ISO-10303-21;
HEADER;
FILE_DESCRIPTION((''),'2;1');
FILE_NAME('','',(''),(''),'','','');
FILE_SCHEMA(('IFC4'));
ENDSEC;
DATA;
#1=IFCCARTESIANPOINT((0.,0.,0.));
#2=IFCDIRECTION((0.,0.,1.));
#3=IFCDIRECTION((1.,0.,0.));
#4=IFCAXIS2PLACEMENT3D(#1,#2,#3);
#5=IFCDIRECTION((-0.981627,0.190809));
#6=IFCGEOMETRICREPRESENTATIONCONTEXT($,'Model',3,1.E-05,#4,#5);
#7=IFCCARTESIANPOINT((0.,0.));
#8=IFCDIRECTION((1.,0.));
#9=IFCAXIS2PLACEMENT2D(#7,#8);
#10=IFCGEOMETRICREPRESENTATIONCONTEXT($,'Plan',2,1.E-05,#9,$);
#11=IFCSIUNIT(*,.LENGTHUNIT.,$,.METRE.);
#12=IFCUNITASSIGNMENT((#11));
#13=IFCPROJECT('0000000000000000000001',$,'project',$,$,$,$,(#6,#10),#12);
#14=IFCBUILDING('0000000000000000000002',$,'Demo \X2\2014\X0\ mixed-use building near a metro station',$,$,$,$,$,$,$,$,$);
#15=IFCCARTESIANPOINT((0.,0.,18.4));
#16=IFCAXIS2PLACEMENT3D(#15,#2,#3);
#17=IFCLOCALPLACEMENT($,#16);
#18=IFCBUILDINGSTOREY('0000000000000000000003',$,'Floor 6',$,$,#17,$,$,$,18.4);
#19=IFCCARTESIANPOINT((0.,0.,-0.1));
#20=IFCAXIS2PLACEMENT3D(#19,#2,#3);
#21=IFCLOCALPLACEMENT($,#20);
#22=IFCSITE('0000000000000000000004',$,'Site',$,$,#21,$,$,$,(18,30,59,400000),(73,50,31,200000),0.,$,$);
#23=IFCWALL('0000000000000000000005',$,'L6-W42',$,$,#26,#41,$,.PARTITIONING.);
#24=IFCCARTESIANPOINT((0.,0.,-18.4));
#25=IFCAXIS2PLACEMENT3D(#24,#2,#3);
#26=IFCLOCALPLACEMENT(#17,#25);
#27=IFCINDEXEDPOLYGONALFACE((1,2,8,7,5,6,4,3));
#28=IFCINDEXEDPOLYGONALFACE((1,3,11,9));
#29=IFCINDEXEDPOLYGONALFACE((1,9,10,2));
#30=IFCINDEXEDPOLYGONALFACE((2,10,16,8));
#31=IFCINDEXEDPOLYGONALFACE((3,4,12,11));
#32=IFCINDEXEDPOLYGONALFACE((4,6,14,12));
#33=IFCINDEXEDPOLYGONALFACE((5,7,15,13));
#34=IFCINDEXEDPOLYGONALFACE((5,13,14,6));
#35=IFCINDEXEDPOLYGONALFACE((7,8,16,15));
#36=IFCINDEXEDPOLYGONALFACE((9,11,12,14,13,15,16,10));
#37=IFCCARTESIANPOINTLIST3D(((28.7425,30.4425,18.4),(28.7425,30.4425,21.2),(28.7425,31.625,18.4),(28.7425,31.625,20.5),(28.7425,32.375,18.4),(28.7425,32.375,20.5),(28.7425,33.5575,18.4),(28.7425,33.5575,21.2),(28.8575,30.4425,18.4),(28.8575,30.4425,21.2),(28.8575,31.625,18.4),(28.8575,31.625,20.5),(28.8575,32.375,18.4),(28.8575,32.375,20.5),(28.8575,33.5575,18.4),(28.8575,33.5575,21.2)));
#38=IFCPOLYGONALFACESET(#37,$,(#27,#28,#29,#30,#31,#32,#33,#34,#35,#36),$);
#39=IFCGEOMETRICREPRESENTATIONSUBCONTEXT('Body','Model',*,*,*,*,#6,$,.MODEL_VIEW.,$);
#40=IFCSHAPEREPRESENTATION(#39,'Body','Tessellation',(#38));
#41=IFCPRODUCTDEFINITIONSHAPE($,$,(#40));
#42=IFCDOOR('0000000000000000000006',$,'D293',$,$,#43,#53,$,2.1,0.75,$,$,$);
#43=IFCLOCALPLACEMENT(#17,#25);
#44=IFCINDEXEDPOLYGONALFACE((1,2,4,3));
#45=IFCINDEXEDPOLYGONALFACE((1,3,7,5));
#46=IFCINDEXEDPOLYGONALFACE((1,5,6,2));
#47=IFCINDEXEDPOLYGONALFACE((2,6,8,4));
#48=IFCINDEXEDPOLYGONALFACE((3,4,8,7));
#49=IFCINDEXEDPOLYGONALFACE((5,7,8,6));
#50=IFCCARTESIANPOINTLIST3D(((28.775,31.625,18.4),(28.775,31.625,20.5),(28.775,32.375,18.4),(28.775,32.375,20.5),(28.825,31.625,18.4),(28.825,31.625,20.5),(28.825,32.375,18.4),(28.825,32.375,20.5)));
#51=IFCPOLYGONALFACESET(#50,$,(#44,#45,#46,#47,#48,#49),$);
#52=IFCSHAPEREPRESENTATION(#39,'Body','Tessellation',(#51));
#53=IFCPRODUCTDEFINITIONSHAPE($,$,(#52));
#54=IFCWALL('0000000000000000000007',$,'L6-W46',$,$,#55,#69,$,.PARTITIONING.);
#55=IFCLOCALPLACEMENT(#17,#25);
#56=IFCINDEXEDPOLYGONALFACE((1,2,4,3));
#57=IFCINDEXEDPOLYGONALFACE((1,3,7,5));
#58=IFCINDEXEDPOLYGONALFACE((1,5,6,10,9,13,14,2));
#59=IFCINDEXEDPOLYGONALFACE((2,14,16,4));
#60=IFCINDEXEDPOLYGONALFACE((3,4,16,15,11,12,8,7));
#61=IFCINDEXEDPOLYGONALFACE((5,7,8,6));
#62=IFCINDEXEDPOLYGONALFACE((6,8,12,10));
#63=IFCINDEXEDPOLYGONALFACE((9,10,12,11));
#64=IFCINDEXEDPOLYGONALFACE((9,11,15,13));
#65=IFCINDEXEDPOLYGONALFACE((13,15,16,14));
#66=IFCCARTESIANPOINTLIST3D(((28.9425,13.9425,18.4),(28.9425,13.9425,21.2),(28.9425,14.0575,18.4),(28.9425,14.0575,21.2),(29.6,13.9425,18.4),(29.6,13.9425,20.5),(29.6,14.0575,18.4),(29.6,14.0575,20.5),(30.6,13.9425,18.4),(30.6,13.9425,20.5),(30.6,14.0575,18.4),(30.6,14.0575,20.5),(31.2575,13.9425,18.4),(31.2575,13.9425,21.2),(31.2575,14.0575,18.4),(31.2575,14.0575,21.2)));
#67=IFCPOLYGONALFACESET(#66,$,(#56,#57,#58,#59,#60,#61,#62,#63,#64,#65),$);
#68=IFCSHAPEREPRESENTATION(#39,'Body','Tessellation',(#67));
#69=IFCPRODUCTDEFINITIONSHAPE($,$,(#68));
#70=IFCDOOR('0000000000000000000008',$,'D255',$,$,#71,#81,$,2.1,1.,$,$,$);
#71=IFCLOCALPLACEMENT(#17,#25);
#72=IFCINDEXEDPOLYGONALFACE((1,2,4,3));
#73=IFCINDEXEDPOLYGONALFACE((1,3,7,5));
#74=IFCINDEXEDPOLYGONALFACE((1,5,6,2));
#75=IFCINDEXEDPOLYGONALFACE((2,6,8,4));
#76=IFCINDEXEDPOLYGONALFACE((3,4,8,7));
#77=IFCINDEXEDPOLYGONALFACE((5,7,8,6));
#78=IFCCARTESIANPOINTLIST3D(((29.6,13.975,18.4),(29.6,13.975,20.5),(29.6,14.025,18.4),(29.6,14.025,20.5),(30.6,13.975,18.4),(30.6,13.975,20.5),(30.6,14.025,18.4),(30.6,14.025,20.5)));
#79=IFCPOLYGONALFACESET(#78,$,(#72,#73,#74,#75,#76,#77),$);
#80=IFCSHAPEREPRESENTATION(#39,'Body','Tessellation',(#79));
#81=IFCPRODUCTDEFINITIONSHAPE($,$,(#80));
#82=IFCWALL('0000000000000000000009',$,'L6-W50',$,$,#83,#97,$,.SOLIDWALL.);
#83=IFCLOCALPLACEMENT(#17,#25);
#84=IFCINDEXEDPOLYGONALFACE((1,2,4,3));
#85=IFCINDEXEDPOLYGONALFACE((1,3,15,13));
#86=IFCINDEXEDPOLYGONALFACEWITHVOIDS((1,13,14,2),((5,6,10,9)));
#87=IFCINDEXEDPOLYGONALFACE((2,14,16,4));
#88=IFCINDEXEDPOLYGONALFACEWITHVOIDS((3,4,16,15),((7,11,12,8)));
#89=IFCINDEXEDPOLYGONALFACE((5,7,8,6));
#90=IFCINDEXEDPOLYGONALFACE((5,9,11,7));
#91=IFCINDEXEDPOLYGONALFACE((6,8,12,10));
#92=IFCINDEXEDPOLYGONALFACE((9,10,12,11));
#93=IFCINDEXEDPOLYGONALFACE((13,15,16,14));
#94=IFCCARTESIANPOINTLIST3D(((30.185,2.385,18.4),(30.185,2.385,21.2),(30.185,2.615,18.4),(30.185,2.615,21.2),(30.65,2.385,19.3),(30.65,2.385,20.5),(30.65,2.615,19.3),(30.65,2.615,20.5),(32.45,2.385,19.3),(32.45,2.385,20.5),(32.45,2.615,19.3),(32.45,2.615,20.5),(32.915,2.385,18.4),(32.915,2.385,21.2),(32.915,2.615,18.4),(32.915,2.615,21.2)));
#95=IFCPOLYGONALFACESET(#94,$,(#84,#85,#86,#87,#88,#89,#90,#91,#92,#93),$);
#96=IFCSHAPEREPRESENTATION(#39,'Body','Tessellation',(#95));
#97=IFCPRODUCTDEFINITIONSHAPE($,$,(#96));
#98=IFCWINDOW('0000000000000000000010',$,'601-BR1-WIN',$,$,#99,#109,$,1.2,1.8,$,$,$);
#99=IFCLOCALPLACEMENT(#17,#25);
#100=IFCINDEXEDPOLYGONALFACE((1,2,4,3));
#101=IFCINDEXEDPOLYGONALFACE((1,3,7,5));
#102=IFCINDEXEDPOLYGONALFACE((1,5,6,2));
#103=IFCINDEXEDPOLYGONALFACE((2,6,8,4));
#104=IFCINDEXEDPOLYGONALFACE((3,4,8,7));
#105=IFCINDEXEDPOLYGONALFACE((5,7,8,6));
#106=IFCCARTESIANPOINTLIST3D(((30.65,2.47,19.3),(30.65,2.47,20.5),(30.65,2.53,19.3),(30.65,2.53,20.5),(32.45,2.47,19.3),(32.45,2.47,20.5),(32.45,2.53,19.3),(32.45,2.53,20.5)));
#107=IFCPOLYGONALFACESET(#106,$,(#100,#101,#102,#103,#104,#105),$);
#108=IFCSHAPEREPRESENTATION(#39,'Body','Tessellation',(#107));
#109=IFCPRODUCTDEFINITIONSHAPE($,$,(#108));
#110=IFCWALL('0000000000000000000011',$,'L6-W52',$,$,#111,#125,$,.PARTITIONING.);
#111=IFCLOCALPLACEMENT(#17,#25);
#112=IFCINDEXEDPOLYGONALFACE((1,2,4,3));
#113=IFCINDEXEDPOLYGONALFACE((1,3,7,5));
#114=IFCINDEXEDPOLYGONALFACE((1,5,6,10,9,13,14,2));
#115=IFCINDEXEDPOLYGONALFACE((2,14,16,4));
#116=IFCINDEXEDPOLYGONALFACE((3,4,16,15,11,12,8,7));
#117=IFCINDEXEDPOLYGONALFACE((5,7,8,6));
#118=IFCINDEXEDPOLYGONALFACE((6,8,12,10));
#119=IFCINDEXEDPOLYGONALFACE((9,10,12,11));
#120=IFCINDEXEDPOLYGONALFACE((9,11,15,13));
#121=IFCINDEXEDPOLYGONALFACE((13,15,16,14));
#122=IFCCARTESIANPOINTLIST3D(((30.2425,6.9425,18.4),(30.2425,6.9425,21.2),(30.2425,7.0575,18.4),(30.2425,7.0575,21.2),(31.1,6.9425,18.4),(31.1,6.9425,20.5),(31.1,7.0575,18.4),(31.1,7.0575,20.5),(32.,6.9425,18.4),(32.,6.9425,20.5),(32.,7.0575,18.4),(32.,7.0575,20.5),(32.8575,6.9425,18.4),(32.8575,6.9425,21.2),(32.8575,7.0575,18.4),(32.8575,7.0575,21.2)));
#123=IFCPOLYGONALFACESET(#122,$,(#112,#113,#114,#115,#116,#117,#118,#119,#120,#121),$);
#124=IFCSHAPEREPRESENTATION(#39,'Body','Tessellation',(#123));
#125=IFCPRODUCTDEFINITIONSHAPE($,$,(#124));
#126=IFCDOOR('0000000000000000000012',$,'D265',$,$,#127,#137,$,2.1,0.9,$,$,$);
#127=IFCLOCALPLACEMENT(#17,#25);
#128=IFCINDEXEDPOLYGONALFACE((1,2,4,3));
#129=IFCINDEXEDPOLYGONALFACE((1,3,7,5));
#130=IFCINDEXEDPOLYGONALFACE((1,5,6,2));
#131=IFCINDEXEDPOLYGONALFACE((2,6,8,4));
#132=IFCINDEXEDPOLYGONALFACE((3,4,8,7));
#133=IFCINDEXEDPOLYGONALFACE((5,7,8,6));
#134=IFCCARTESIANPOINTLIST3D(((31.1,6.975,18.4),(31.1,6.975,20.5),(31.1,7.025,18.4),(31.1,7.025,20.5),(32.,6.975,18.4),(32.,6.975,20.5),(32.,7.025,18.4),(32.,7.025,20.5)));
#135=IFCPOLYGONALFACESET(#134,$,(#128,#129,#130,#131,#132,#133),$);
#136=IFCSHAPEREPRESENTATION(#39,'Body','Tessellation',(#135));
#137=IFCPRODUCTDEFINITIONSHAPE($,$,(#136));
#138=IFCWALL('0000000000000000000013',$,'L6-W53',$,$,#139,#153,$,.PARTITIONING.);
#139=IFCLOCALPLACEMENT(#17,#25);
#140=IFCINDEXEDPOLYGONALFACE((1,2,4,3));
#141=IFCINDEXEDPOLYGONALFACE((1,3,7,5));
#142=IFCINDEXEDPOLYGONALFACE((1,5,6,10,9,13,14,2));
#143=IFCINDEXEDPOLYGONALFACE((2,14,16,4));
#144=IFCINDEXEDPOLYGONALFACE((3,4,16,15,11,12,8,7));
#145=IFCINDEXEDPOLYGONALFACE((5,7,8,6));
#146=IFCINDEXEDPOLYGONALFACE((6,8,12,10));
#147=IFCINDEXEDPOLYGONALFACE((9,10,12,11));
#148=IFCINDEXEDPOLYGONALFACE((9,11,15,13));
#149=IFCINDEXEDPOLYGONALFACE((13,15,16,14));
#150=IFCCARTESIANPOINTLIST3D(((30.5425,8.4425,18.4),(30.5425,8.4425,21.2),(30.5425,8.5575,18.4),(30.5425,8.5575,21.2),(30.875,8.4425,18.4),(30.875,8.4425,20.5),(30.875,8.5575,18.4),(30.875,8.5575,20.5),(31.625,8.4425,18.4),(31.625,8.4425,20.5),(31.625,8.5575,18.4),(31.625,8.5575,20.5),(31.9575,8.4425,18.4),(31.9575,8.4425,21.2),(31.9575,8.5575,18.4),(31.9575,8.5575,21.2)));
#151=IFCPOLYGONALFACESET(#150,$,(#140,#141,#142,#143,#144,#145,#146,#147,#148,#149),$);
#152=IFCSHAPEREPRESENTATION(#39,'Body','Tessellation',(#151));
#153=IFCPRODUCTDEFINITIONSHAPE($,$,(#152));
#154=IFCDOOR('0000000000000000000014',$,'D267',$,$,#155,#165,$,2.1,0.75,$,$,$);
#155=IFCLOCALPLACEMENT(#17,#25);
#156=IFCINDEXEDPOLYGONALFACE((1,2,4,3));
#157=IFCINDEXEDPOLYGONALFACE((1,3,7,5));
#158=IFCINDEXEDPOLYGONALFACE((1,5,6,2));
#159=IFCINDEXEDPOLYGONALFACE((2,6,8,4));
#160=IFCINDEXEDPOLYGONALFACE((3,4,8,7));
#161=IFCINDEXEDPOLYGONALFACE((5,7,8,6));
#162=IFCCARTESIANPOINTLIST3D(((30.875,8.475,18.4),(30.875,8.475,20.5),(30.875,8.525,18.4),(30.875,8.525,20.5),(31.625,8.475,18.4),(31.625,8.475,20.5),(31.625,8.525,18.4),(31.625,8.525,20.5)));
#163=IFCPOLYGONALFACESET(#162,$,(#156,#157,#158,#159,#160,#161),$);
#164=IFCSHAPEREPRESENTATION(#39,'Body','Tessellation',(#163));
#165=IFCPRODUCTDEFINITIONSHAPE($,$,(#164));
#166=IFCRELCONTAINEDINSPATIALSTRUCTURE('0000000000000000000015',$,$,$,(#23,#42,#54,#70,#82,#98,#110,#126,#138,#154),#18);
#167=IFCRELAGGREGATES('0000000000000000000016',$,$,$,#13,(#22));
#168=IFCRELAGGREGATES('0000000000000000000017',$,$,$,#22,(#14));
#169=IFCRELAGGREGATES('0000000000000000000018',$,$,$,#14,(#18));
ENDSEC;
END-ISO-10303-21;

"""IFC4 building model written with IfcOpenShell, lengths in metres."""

from ifc_helpers import new_model, si_unit, direction, frame, origin_with_axes, origin_2d_with_axis, place, context, subcontext, project, spatial, line, indexed_curve, outline, extrude, element, fill, save


model = new_model("IFC4")

# Units and contexts
model_context = context("Model", 3, precision=1e-05, world=origin_with_axes(), true_north=direction((-0.981627, 0.190809)))
plan_context = context("Plan", 2, precision=1e-05, world=origin_2d_with_axis())
body_context = subcontext(model_context, "Body", "Model", "MODEL_VIEW")
ifc_project = project(units=[si_unit("LENGTHUNIT", "METRE")], contexts=[model_context, plan_context])

# Site, building, storey
site_placement = place(None, frame((0.0, 0.0, -0.1), z_axis=(0.0, 0.0, 1.0), x_axis=(1.0, 0.0, 0.0)))
site = spatial("IfcSite", under=ifc_project, at=site_placement, Name="Site", RefLatitude=(18, 30, 59, 400000), RefLongitude=(73, 50, 31, 200000), RefElevation=0.0)
building = spatial("IfcBuilding", under=site, Name="Demo — mixed-use building near a metro station")
storey_placement = place(None, frame((0.0, 0.0, 18.4), z_axis=(0.0, 0.0, 1.0), x_axis=(1.0, 0.0, 0.0)))
storey = spatial("IfcBuildingStorey", under=building, at=storey_placement, Name="Floor 6", Elevation=18.4)

# Wall, opening, door
wall_1_placement = place(storey_placement, frame((0.0, 0.0, -18.4), z_axis=(0.0, 0.0, 1.0), x_axis=(1.0, 0.0, 0.0)))
wall_1 = element("IfcWall", 1, at=wall_1_placement, inside=storey, Name="L6-W42", PredefinedType="PARTITIONING", context=body_context, shape_type="SweptSolid", body=[
    extrude(outline(indexed_curve([(28.7425, 30.4425), (28.7425, 33.5575), (28.8575, 33.5575), (28.8575, 30.4425)], segments=[line(1, 2, 3, 4, 1)])), frame((0.0, 0.0, 18.4), z_axis=(0.0, 0.0, 1.0), x_axis=(1.0, 0.0, 0.0)), (0.0, 0.0, 1.0), 2.8),
])
opening_1_placement = place(wall_1_placement, origin_with_axes())
opening_1 = element("IfcOpeningElement", 2, at=opening_1_placement, cuts=wall_1, context=body_context, shape_type="SweptSolid", body=[
    extrude(outline(indexed_curve([(28.6925, 31.625), (28.6925, 32.375), (28.9075, 32.375), (28.9075, 31.625)], segments=[line(1, 2, 3, 4, 1)])), frame((0.0, 0.0, 18.4), z_axis=(0.0, 0.0, 1.0), x_axis=(1.0, 0.0, 0.0)), (0.0, 0.0, 1.0), 2.1),
])
door_1_placement = place(storey_placement, frame((0.0, 0.0, -18.4), z_axis=(0.0, 0.0, 1.0), x_axis=(1.0, 0.0, 0.0)))
door_1 = element("IfcDoor", 3, at=door_1_placement, inside=storey, Name="D293", OverallHeight=2.1, OverallWidth=0.75, context=body_context, shape_type="SweptSolid", body=[
    extrude(outline(indexed_curve([(28.775, 31.625), (28.775, 32.375), (28.825, 32.375), (28.825, 31.625)], segments=[line(1, 2, 3, 4, 1)])), frame((0.0, 0.0, 18.4), z_axis=(0.0, 0.0, 1.0), x_axis=(1.0, 0.0, 0.0)), (0.0, 0.0, 1.0), 2.1),
])
fill(opening_1, door_1)

# Wall, opening, door
wall_2_placement = place(storey_placement, frame((0.0, 0.0, -18.4), z_axis=(0.0, 0.0, 1.0), x_axis=(1.0, 0.0, 0.0)))
wall_2 = element("IfcWall", 4, at=wall_2_placement, inside=storey, Name="L6-W46", PredefinedType="PARTITIONING", context=body_context, shape_type="SweptSolid", body=[
    extrude(outline(indexed_curve([(31.2575, 13.9425), (28.9425, 13.9425), (28.9425, 14.0575), (31.2575, 14.0575)], segments=[line(1, 2, 3, 4, 1)])), frame((0.0, 0.0, 18.4), z_axis=(0.0, 0.0, 1.0), x_axis=(1.0, 0.0, 0.0)), (0.0, 0.0, 1.0), 2.8),
])
opening_2_placement = place(wall_2_placement, origin_with_axes())
opening_2 = element("IfcOpeningElement", 5, at=opening_2_placement, cuts=wall_2, context=body_context, shape_type="SweptSolid", body=[
    extrude(outline(indexed_curve([(30.6, 13.8925), (29.6, 13.8925), (29.6, 14.1075), (30.6, 14.1075)], segments=[line(1, 2, 3, 4, 1)])), frame((0.0, 0.0, 18.4), z_axis=(0.0, 0.0, 1.0), x_axis=(1.0, 0.0, 0.0)), (0.0, 0.0, 1.0), 2.1),
])
door_2_placement = place(storey_placement, frame((0.0, 0.0, -18.4), z_axis=(0.0, 0.0, 1.0), x_axis=(1.0, 0.0, 0.0)))
door_2 = element("IfcDoor", 6, at=door_2_placement, inside=storey, Name="D255", OverallHeight=2.1, OverallWidth=1.0, context=body_context, shape_type="SweptSolid", body=[
    extrude(outline(indexed_curve([(30.6, 13.975), (29.6, 13.975), (29.6, 14.025), (30.6, 14.025)], segments=[line(1, 2, 3, 4, 1)])), frame((0.0, 0.0, 18.4), z_axis=(0.0, 0.0, 1.0), x_axis=(1.0, 0.0, 0.0)), (0.0, 0.0, 1.0), 2.1),
])
fill(opening_2, door_2)

# Wall, opening, window
wall_3_placement = place(storey_placement, frame((0.0, 0.0, -18.4), z_axis=(0.0, 0.0, 1.0), x_axis=(1.0, 0.0, 0.0)))
wall_3 = element("IfcWall", 7, at=wall_3_placement, inside=storey, Name="L6-W50", PredefinedType="SOLIDWALL", context=body_context, shape_type="SweptSolid", body=[
    extrude(outline(indexed_curve([(30.185, 2.615), (32.915, 2.615), (32.915, 2.385), (30.185, 2.385)], segments=[line(1, 2, 3, 4, 1)])), frame((0.0, 0.0, 18.4), z_axis=(0.0, 0.0, 1.0), x_axis=(1.0, 0.0, 0.0)), (0.0, 0.0, 1.0), 2.8),
])
opening_3_placement = place(wall_3_placement, origin_with_axes())
opening_3 = element("IfcOpeningElement", 8, at=opening_3_placement, cuts=wall_3, context=body_context, shape_type="SweptSolid", body=[
    extrude(outline(indexed_curve([(30.65, 2.665), (32.45, 2.665), (32.45, 2.335), (30.65, 2.335)], segments=[line(1, 2, 3, 4, 1)])), frame((0.0, 0.0, 19.3), z_axis=(0.0, 0.0, 1.0), x_axis=(1.0, 0.0, 0.0)), (0.0, 0.0, 1.0), 1.2),
])
window_placement = place(storey_placement, frame((0.0, 0.0, -18.4), z_axis=(0.0, 0.0, 1.0), x_axis=(1.0, 0.0, 0.0)))
window = element("IfcWindow", 9, at=window_placement, inside=storey, Name="601-BR1-WIN", OverallHeight=1.2, OverallWidth=1.8, context=body_context, shape_type="SweptSolid", body=[
    extrude(outline(indexed_curve([(30.65, 2.53), (32.45, 2.53), (32.45, 2.47), (30.65, 2.47)], segments=[line(1, 2, 3, 4, 1)])), frame((0.0, 0.0, 19.3), z_axis=(0.0, 0.0, 1.0), x_axis=(1.0, 0.0, 0.0)), (0.0, 0.0, 1.0), 1.2),
])
fill(opening_3, window)

# Walls, openings, doors
wall_4_placement = place(storey_placement, frame((0.0, 0.0, -18.4), z_axis=(0.0, 0.0, 1.0), x_axis=(1.0, 0.0, 0.0)))
wall_4 = element("IfcWall", 10, at=wall_4_placement, inside=storey, Name="L6-W52", PredefinedType="PARTITIONING", context=body_context, shape_type="SweptSolid", body=[
    extrude(outline(indexed_curve([(32.8575, 6.9425), (30.2425, 6.9425), (30.2425, 7.0575), (32.8575, 7.0575)], segments=[line(1, 2, 3, 4, 1)])), frame((0.0, 0.0, 18.4), z_axis=(0.0, 0.0, 1.0), x_axis=(1.0, 0.0, 0.0)), (0.0, 0.0, 1.0), 2.8),
])
opening_4_placement = place(wall_4_placement, origin_with_axes())
opening_4 = element("IfcOpeningElement", 11, at=opening_4_placement, cuts=wall_4, context=body_context, shape_type="SweptSolid", body=[
    extrude(outline(indexed_curve([(32.0, 6.8925), (31.1, 6.8925), (31.1, 7.1075), (32.0, 7.1075)], segments=[line(1, 2, 3, 4, 1)])), frame((0.0, 0.0, 18.4), z_axis=(0.0, 0.0, 1.0), x_axis=(1.0, 0.0, 0.0)), (0.0, 0.0, 1.0), 2.1),
])
door_3_placement = place(storey_placement, frame((0.0, 0.0, -18.4), z_axis=(0.0, 0.0, 1.0), x_axis=(1.0, 0.0, 0.0)))
door_3 = element("IfcDoor", 12, at=door_3_placement, inside=storey, Name="D265", OverallHeight=2.1, OverallWidth=0.9, context=body_context, shape_type="SweptSolid", body=[
    extrude(outline(indexed_curve([(32.0, 6.975), (31.1, 6.975), (31.1, 7.025), (32.0, 7.025)], segments=[line(1, 2, 3, 4, 1)])), frame((0.0, 0.0, 18.4), z_axis=(0.0, 0.0, 1.0), x_axis=(1.0, 0.0, 0.0)), (0.0, 0.0, 1.0), 2.1),
])
fill(opening_4, door_3)
wall_5_placement = place(storey_placement, frame((0.0, 0.0, -18.4), z_axis=(0.0, 0.0, 1.0), x_axis=(1.0, 0.0, 0.0)))
wall_5 = element("IfcWall", 13, at=wall_5_placement, inside=storey, Name="L6-W53", PredefinedType="PARTITIONING", context=body_context, shape_type="SweptSolid", body=[
    extrude(outline(indexed_curve([(31.9575, 8.4425), (30.5425, 8.4425), (30.5425, 8.5575), (31.9575, 8.5575)], segments=[line(1, 2, 3, 4, 1)])), frame((0.0, 0.0, 18.4), z_axis=(0.0, 0.0, 1.0), x_axis=(1.0, 0.0, 0.0)), (0.0, 0.0, 1.0), 2.8),
])
opening_5_placement = place(wall_5_placement, origin_with_axes())
opening_5 = element("IfcOpeningElement", 14, at=opening_5_placement, cuts=wall_5, context=body_context, shape_type="SweptSolid", body=[
    extrude(outline(indexed_curve([(31.625, 8.3925), (30.875, 8.3925), (30.875, 8.6075), (31.625, 8.6075)], segments=[line(1, 2, 3, 4, 1)])), frame((0.0, 0.0, 18.4), z_axis=(0.0, 0.0, 1.0), x_axis=(1.0, 0.0, 0.0)), (0.0, 0.0, 1.0), 2.1),
])
door_4_placement = place(storey_placement, frame((0.0, 0.0, -18.4), z_axis=(0.0, 0.0, 1.0), x_axis=(1.0, 0.0, 0.0)))
door_4 = element("IfcDoor", 15, at=door_4_placement, inside=storey, Name="D267", OverallHeight=2.1, OverallWidth=0.75, context=body_context, shape_type="SweptSolid", body=[
    extrude(outline(indexed_curve([(31.625, 8.475), (30.875, 8.475), (30.875, 8.525), (31.625, 8.525)], segments=[line(1, 2, 3, 4, 1)])), frame((0.0, 0.0, 18.4), z_axis=(0.0, 0.0, 1.0), x_axis=(1.0, 0.0, 0.0)), (0.0, 0.0, 1.0), 2.1),
])
fill(opening_5, door_4)

save(model, "model.ifc")
